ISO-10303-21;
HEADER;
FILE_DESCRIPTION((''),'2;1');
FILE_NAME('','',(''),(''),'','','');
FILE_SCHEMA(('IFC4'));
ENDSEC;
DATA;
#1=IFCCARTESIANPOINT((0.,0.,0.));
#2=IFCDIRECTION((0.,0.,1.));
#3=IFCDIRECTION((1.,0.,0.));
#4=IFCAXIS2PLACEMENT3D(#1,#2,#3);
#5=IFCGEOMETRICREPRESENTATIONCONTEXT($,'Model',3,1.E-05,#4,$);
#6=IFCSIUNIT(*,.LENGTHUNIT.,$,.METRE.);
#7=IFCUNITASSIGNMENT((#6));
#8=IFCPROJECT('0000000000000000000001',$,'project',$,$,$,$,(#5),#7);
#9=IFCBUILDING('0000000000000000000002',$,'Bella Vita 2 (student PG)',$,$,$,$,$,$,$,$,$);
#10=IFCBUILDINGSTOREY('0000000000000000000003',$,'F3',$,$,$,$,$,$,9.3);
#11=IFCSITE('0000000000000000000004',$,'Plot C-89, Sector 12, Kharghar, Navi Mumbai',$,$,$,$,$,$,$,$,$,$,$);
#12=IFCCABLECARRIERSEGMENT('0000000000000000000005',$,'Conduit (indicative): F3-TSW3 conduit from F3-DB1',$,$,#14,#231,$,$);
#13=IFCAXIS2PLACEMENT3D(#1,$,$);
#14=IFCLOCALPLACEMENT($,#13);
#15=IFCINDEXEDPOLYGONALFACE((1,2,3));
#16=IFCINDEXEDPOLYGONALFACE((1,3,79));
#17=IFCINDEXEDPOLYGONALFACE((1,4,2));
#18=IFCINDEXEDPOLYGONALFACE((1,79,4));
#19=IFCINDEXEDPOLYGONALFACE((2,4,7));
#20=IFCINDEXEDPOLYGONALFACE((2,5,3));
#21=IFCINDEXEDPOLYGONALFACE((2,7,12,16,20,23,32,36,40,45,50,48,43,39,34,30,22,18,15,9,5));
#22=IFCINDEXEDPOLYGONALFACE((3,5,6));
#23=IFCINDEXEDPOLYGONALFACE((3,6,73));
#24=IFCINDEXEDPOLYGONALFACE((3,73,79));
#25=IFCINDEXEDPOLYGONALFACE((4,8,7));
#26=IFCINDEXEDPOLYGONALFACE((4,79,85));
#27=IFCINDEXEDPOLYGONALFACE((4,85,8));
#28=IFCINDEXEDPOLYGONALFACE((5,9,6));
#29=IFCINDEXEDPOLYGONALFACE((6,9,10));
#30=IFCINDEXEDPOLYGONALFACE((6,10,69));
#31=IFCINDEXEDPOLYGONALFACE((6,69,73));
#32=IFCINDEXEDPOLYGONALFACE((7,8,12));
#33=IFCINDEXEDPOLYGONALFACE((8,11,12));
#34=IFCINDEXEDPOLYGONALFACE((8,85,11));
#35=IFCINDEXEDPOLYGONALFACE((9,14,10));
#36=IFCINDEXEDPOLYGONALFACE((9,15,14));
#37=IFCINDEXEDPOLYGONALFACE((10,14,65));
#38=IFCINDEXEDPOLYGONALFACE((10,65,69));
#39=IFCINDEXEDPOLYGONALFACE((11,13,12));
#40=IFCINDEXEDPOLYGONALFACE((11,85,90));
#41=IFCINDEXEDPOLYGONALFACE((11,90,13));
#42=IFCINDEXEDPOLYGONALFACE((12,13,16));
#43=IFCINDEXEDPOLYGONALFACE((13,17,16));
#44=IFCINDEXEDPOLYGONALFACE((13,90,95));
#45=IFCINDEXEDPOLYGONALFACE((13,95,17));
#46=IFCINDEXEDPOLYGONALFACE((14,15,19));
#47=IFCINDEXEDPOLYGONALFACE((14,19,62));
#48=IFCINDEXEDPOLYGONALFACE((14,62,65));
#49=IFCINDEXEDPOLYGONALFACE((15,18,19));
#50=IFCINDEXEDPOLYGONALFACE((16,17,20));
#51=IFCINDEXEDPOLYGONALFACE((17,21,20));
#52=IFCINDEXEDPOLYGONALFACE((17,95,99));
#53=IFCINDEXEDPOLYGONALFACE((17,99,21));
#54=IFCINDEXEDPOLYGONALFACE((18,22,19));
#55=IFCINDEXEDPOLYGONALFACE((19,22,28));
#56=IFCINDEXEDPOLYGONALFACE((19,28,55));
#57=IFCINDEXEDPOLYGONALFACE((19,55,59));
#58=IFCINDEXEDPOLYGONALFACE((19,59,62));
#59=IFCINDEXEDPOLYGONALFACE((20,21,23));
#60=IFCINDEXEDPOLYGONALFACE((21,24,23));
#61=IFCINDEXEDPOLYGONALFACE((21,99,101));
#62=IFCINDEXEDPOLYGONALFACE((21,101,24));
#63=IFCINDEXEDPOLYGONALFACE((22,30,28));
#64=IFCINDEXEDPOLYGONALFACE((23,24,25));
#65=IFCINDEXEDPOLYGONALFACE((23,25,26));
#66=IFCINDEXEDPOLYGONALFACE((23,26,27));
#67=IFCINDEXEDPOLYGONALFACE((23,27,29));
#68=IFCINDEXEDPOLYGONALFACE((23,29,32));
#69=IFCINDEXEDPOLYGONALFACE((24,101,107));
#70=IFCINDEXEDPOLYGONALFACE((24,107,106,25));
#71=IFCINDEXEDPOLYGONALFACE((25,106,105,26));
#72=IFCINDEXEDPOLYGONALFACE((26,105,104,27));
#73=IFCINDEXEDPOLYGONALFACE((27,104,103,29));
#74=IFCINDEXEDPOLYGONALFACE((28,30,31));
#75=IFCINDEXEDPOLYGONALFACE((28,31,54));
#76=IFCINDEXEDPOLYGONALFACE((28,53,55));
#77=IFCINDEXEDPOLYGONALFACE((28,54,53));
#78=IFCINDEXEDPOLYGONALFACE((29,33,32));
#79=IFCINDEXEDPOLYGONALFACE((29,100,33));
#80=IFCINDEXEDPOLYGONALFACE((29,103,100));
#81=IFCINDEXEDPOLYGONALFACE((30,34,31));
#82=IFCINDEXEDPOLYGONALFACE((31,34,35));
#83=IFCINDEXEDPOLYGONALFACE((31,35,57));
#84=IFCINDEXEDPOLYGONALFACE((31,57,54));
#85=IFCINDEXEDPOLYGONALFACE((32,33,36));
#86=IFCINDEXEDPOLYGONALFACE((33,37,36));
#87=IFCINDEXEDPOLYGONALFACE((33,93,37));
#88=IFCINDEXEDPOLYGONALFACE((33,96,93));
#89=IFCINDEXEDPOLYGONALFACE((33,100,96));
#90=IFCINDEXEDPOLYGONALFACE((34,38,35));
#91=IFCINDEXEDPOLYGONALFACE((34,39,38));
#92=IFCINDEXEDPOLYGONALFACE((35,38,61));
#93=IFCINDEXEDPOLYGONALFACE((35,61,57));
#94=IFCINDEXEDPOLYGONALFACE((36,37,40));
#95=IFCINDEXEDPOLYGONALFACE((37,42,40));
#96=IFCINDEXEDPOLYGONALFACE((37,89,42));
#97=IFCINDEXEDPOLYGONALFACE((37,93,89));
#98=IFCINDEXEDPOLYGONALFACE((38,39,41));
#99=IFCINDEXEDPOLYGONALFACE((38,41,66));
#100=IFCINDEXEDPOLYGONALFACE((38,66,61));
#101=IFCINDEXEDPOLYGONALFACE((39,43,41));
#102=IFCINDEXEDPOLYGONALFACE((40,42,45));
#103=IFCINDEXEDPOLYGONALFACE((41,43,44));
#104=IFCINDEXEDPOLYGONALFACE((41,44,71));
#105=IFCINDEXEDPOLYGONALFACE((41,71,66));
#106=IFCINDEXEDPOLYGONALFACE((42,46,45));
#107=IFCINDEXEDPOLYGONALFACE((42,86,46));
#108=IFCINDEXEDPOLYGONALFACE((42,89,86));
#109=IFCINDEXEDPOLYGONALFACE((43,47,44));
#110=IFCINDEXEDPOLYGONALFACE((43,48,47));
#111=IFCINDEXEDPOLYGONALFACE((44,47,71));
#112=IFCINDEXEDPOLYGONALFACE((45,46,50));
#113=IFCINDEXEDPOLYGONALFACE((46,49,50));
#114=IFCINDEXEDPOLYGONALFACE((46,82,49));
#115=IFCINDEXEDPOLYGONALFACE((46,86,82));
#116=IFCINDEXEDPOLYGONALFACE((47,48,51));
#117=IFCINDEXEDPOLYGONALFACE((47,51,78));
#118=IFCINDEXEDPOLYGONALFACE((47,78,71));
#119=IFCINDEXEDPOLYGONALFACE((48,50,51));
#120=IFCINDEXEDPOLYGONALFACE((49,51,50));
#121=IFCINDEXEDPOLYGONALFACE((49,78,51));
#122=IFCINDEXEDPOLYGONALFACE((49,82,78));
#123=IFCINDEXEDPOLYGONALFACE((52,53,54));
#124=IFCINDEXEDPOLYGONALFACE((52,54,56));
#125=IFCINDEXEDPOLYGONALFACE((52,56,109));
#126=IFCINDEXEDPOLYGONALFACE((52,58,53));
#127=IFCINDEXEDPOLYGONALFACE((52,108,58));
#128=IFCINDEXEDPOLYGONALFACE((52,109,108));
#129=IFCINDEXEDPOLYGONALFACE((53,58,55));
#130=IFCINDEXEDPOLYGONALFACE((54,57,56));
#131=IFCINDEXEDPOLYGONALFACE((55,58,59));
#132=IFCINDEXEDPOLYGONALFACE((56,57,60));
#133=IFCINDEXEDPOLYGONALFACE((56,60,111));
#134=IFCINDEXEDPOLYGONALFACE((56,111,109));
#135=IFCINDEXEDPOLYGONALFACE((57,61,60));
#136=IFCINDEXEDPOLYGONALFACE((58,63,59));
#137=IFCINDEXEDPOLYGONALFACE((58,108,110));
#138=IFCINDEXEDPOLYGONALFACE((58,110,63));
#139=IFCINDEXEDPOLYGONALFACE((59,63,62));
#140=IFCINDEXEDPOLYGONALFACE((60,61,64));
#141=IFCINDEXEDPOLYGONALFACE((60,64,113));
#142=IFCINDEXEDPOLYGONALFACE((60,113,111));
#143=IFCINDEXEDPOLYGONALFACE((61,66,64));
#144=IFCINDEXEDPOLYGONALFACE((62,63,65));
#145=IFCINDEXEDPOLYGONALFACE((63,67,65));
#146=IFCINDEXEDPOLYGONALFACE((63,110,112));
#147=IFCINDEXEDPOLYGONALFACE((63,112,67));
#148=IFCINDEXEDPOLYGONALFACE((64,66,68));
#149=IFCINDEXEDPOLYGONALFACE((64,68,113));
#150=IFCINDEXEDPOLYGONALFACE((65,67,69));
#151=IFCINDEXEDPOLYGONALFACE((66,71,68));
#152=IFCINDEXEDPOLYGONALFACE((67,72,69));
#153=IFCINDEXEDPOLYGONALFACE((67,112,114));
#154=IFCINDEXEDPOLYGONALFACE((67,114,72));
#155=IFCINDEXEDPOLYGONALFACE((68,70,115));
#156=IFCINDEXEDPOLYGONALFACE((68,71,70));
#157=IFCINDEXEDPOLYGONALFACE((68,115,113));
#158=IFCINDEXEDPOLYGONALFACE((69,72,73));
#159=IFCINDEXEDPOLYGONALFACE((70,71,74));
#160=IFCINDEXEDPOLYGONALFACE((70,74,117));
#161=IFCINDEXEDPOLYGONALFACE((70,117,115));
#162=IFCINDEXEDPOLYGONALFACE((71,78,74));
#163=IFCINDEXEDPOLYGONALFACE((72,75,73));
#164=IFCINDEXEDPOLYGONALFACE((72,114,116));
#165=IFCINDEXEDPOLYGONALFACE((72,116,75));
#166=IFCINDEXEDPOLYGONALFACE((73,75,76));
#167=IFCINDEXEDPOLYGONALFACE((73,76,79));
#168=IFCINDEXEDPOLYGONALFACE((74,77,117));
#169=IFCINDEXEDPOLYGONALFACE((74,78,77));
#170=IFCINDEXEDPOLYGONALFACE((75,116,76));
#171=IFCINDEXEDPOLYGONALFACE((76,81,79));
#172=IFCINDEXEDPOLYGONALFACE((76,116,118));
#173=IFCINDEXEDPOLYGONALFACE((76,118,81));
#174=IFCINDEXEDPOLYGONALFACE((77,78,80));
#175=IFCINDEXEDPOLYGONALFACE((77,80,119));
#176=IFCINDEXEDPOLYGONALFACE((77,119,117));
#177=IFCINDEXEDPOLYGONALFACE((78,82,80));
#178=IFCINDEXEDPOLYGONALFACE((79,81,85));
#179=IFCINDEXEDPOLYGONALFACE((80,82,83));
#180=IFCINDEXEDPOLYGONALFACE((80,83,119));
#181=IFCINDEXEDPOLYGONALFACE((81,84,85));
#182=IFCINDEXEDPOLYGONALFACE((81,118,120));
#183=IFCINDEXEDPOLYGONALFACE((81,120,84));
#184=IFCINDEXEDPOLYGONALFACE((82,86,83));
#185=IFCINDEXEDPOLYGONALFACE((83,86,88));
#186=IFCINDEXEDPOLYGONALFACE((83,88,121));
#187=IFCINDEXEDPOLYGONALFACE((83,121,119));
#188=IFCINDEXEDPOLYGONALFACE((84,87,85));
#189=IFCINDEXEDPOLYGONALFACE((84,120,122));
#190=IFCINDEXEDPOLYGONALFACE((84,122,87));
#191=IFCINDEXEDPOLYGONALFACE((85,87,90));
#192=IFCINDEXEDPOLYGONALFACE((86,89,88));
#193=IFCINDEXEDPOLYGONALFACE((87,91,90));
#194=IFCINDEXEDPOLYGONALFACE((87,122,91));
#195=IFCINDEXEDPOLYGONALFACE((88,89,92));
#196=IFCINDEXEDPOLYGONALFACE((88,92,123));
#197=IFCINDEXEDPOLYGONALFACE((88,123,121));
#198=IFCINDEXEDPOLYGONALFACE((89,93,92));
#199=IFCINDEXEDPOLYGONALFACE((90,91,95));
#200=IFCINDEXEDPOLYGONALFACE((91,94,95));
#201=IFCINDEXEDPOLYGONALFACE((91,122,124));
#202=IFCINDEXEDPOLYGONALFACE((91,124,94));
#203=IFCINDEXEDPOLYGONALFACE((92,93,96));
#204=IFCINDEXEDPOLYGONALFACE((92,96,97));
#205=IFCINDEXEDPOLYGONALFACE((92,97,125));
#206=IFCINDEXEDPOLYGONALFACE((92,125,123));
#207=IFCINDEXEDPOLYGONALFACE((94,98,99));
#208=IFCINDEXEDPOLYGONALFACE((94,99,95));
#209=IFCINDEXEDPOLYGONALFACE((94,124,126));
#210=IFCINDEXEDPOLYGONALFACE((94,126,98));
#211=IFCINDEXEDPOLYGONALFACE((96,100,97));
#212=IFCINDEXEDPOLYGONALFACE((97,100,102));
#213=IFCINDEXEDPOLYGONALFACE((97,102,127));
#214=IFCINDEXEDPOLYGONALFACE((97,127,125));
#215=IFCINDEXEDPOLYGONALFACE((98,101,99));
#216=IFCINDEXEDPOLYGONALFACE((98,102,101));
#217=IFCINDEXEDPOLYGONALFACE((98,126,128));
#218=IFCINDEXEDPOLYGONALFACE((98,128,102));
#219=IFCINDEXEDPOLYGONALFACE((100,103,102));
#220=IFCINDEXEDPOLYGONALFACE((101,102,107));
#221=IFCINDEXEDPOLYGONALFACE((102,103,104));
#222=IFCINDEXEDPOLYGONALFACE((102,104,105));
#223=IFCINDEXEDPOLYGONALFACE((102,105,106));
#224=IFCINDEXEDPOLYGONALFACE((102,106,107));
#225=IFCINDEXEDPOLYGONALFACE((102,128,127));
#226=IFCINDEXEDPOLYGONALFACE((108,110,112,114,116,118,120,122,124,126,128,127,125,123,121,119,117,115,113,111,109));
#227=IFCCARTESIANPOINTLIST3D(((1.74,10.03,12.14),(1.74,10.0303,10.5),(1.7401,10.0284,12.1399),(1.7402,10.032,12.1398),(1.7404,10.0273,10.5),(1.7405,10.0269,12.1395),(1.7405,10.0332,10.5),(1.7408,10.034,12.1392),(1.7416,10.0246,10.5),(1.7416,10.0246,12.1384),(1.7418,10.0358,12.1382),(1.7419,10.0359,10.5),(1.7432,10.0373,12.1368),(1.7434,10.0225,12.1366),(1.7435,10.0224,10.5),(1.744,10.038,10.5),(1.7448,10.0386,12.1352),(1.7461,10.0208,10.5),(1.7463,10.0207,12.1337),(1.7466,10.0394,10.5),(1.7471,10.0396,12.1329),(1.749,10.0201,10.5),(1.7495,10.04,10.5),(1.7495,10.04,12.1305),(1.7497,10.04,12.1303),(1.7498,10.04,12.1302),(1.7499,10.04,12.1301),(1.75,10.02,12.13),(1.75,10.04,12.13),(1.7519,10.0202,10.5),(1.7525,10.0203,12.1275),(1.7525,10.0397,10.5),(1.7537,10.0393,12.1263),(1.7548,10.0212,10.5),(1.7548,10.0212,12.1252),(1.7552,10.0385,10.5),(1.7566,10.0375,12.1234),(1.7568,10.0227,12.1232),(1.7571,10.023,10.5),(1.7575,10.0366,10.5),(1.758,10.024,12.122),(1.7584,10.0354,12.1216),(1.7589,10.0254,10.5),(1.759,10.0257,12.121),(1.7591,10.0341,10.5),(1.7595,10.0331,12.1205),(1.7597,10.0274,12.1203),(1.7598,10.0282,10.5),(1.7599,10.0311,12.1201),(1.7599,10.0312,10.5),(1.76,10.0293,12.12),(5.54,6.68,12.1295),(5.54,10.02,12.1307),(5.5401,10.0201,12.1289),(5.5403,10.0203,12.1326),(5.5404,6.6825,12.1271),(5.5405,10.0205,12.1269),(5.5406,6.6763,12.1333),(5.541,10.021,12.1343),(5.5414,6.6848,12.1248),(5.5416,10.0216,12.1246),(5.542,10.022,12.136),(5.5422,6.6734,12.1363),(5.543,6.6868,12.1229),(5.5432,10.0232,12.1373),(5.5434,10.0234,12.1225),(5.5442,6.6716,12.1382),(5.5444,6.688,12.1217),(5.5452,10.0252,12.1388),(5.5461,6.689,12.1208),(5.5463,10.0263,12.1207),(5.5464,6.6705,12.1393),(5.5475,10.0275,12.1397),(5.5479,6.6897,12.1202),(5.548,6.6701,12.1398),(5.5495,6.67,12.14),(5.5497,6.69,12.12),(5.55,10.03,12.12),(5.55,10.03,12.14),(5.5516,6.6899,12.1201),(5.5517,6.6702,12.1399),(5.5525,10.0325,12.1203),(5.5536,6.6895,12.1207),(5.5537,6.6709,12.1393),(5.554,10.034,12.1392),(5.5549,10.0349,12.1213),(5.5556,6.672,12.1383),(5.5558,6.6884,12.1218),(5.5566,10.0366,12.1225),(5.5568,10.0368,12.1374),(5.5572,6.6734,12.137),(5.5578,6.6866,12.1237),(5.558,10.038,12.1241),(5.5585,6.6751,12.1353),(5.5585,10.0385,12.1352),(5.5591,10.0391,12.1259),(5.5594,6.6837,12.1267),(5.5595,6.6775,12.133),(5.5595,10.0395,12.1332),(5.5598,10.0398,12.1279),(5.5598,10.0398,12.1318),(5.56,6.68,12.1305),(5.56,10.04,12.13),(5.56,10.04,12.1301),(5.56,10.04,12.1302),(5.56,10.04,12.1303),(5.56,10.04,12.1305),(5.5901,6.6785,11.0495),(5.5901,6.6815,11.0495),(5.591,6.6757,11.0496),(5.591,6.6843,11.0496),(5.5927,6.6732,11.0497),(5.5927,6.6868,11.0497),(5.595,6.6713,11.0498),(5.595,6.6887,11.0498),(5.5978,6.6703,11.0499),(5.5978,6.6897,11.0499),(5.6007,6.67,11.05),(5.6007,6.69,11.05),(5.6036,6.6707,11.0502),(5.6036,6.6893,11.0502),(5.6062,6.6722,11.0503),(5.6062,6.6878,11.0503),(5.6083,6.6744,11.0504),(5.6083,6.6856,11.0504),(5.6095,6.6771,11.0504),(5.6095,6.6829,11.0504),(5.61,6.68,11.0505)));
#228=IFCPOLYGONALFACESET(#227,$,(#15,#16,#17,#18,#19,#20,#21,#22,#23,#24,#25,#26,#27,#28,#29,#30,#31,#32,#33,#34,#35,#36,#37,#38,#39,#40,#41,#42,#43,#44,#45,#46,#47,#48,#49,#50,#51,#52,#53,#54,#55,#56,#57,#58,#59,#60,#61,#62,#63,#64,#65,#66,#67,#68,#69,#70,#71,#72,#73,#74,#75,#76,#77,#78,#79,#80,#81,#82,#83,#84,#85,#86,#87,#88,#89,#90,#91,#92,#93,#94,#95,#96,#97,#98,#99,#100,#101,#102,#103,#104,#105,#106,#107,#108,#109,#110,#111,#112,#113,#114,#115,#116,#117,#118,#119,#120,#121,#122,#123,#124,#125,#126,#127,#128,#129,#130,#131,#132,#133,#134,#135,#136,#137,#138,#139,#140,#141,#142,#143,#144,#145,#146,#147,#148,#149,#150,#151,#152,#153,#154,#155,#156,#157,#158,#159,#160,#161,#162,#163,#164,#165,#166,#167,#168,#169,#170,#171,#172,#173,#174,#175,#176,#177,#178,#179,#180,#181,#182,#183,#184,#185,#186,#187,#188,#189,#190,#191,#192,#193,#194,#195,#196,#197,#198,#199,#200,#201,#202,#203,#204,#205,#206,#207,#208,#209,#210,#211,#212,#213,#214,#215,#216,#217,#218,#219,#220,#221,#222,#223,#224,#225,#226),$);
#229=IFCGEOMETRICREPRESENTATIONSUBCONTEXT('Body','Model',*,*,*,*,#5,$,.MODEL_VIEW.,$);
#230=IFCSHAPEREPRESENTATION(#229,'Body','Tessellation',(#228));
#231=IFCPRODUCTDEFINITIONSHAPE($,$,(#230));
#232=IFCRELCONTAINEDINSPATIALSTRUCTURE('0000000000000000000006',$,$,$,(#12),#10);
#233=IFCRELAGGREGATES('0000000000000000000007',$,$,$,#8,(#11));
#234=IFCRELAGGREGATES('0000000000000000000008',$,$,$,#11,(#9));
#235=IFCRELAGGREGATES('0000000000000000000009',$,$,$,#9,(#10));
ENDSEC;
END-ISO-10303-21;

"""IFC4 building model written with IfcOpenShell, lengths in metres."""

from ifc_helpers import new_model, entity, si_unit, origin, origin_with_axes, place, context, subcontext, project, spatial, element, save


model = new_model("IFC4")

# Units and contexts
model_context = context("Model", 3, precision=1e-05, world=origin_with_axes())
body_context = subcontext(model_context, "Body", "Model", "MODEL_VIEW")
ifc_project = project(units=[si_unit("LENGTHUNIT", "METRE")], contexts=[model_context])

# Site, building, storey
site = spatial("IfcSite", under=ifc_project, Name="Plot C-89, Sector 12, Kharghar, Navi Mumbai")
building = spatial("IfcBuilding", under=site, Name="Bella Vita 2 (student PG)")
storey = spatial("IfcBuildingStorey", under=building, Name="F3", Elevation=9.3)

# Cable carrier segment
cable_carrier_segment_1_placement = place(None, origin())
element("IfcCableCarrierSegment", 1, at=cable_carrier_segment_1_placement, inside=storey, Name="Conduit (indicative): F3-TSW3 conduit from F3-DB1", context=body_context, shape_type="AdvancedSweptSolid", body=[
    entity("IfcSweptDiskSolid", entity("IfcPolyline", [entity("IfcCartesianPoint", [5.6, 6.68, 11.05]), entity("IfcCartesianPoint", [5.55, 6.68, 12.13]), entity("IfcCartesianPoint", [5.55, 10.03, 12.13]), entity("IfcCartesianPoint", [1.75, 10.03, 12.13]), entity("IfcCartesianPoint", [1.75, 10.03, 10.5])]), 0.01),
])

save(model, "model.ifc")
